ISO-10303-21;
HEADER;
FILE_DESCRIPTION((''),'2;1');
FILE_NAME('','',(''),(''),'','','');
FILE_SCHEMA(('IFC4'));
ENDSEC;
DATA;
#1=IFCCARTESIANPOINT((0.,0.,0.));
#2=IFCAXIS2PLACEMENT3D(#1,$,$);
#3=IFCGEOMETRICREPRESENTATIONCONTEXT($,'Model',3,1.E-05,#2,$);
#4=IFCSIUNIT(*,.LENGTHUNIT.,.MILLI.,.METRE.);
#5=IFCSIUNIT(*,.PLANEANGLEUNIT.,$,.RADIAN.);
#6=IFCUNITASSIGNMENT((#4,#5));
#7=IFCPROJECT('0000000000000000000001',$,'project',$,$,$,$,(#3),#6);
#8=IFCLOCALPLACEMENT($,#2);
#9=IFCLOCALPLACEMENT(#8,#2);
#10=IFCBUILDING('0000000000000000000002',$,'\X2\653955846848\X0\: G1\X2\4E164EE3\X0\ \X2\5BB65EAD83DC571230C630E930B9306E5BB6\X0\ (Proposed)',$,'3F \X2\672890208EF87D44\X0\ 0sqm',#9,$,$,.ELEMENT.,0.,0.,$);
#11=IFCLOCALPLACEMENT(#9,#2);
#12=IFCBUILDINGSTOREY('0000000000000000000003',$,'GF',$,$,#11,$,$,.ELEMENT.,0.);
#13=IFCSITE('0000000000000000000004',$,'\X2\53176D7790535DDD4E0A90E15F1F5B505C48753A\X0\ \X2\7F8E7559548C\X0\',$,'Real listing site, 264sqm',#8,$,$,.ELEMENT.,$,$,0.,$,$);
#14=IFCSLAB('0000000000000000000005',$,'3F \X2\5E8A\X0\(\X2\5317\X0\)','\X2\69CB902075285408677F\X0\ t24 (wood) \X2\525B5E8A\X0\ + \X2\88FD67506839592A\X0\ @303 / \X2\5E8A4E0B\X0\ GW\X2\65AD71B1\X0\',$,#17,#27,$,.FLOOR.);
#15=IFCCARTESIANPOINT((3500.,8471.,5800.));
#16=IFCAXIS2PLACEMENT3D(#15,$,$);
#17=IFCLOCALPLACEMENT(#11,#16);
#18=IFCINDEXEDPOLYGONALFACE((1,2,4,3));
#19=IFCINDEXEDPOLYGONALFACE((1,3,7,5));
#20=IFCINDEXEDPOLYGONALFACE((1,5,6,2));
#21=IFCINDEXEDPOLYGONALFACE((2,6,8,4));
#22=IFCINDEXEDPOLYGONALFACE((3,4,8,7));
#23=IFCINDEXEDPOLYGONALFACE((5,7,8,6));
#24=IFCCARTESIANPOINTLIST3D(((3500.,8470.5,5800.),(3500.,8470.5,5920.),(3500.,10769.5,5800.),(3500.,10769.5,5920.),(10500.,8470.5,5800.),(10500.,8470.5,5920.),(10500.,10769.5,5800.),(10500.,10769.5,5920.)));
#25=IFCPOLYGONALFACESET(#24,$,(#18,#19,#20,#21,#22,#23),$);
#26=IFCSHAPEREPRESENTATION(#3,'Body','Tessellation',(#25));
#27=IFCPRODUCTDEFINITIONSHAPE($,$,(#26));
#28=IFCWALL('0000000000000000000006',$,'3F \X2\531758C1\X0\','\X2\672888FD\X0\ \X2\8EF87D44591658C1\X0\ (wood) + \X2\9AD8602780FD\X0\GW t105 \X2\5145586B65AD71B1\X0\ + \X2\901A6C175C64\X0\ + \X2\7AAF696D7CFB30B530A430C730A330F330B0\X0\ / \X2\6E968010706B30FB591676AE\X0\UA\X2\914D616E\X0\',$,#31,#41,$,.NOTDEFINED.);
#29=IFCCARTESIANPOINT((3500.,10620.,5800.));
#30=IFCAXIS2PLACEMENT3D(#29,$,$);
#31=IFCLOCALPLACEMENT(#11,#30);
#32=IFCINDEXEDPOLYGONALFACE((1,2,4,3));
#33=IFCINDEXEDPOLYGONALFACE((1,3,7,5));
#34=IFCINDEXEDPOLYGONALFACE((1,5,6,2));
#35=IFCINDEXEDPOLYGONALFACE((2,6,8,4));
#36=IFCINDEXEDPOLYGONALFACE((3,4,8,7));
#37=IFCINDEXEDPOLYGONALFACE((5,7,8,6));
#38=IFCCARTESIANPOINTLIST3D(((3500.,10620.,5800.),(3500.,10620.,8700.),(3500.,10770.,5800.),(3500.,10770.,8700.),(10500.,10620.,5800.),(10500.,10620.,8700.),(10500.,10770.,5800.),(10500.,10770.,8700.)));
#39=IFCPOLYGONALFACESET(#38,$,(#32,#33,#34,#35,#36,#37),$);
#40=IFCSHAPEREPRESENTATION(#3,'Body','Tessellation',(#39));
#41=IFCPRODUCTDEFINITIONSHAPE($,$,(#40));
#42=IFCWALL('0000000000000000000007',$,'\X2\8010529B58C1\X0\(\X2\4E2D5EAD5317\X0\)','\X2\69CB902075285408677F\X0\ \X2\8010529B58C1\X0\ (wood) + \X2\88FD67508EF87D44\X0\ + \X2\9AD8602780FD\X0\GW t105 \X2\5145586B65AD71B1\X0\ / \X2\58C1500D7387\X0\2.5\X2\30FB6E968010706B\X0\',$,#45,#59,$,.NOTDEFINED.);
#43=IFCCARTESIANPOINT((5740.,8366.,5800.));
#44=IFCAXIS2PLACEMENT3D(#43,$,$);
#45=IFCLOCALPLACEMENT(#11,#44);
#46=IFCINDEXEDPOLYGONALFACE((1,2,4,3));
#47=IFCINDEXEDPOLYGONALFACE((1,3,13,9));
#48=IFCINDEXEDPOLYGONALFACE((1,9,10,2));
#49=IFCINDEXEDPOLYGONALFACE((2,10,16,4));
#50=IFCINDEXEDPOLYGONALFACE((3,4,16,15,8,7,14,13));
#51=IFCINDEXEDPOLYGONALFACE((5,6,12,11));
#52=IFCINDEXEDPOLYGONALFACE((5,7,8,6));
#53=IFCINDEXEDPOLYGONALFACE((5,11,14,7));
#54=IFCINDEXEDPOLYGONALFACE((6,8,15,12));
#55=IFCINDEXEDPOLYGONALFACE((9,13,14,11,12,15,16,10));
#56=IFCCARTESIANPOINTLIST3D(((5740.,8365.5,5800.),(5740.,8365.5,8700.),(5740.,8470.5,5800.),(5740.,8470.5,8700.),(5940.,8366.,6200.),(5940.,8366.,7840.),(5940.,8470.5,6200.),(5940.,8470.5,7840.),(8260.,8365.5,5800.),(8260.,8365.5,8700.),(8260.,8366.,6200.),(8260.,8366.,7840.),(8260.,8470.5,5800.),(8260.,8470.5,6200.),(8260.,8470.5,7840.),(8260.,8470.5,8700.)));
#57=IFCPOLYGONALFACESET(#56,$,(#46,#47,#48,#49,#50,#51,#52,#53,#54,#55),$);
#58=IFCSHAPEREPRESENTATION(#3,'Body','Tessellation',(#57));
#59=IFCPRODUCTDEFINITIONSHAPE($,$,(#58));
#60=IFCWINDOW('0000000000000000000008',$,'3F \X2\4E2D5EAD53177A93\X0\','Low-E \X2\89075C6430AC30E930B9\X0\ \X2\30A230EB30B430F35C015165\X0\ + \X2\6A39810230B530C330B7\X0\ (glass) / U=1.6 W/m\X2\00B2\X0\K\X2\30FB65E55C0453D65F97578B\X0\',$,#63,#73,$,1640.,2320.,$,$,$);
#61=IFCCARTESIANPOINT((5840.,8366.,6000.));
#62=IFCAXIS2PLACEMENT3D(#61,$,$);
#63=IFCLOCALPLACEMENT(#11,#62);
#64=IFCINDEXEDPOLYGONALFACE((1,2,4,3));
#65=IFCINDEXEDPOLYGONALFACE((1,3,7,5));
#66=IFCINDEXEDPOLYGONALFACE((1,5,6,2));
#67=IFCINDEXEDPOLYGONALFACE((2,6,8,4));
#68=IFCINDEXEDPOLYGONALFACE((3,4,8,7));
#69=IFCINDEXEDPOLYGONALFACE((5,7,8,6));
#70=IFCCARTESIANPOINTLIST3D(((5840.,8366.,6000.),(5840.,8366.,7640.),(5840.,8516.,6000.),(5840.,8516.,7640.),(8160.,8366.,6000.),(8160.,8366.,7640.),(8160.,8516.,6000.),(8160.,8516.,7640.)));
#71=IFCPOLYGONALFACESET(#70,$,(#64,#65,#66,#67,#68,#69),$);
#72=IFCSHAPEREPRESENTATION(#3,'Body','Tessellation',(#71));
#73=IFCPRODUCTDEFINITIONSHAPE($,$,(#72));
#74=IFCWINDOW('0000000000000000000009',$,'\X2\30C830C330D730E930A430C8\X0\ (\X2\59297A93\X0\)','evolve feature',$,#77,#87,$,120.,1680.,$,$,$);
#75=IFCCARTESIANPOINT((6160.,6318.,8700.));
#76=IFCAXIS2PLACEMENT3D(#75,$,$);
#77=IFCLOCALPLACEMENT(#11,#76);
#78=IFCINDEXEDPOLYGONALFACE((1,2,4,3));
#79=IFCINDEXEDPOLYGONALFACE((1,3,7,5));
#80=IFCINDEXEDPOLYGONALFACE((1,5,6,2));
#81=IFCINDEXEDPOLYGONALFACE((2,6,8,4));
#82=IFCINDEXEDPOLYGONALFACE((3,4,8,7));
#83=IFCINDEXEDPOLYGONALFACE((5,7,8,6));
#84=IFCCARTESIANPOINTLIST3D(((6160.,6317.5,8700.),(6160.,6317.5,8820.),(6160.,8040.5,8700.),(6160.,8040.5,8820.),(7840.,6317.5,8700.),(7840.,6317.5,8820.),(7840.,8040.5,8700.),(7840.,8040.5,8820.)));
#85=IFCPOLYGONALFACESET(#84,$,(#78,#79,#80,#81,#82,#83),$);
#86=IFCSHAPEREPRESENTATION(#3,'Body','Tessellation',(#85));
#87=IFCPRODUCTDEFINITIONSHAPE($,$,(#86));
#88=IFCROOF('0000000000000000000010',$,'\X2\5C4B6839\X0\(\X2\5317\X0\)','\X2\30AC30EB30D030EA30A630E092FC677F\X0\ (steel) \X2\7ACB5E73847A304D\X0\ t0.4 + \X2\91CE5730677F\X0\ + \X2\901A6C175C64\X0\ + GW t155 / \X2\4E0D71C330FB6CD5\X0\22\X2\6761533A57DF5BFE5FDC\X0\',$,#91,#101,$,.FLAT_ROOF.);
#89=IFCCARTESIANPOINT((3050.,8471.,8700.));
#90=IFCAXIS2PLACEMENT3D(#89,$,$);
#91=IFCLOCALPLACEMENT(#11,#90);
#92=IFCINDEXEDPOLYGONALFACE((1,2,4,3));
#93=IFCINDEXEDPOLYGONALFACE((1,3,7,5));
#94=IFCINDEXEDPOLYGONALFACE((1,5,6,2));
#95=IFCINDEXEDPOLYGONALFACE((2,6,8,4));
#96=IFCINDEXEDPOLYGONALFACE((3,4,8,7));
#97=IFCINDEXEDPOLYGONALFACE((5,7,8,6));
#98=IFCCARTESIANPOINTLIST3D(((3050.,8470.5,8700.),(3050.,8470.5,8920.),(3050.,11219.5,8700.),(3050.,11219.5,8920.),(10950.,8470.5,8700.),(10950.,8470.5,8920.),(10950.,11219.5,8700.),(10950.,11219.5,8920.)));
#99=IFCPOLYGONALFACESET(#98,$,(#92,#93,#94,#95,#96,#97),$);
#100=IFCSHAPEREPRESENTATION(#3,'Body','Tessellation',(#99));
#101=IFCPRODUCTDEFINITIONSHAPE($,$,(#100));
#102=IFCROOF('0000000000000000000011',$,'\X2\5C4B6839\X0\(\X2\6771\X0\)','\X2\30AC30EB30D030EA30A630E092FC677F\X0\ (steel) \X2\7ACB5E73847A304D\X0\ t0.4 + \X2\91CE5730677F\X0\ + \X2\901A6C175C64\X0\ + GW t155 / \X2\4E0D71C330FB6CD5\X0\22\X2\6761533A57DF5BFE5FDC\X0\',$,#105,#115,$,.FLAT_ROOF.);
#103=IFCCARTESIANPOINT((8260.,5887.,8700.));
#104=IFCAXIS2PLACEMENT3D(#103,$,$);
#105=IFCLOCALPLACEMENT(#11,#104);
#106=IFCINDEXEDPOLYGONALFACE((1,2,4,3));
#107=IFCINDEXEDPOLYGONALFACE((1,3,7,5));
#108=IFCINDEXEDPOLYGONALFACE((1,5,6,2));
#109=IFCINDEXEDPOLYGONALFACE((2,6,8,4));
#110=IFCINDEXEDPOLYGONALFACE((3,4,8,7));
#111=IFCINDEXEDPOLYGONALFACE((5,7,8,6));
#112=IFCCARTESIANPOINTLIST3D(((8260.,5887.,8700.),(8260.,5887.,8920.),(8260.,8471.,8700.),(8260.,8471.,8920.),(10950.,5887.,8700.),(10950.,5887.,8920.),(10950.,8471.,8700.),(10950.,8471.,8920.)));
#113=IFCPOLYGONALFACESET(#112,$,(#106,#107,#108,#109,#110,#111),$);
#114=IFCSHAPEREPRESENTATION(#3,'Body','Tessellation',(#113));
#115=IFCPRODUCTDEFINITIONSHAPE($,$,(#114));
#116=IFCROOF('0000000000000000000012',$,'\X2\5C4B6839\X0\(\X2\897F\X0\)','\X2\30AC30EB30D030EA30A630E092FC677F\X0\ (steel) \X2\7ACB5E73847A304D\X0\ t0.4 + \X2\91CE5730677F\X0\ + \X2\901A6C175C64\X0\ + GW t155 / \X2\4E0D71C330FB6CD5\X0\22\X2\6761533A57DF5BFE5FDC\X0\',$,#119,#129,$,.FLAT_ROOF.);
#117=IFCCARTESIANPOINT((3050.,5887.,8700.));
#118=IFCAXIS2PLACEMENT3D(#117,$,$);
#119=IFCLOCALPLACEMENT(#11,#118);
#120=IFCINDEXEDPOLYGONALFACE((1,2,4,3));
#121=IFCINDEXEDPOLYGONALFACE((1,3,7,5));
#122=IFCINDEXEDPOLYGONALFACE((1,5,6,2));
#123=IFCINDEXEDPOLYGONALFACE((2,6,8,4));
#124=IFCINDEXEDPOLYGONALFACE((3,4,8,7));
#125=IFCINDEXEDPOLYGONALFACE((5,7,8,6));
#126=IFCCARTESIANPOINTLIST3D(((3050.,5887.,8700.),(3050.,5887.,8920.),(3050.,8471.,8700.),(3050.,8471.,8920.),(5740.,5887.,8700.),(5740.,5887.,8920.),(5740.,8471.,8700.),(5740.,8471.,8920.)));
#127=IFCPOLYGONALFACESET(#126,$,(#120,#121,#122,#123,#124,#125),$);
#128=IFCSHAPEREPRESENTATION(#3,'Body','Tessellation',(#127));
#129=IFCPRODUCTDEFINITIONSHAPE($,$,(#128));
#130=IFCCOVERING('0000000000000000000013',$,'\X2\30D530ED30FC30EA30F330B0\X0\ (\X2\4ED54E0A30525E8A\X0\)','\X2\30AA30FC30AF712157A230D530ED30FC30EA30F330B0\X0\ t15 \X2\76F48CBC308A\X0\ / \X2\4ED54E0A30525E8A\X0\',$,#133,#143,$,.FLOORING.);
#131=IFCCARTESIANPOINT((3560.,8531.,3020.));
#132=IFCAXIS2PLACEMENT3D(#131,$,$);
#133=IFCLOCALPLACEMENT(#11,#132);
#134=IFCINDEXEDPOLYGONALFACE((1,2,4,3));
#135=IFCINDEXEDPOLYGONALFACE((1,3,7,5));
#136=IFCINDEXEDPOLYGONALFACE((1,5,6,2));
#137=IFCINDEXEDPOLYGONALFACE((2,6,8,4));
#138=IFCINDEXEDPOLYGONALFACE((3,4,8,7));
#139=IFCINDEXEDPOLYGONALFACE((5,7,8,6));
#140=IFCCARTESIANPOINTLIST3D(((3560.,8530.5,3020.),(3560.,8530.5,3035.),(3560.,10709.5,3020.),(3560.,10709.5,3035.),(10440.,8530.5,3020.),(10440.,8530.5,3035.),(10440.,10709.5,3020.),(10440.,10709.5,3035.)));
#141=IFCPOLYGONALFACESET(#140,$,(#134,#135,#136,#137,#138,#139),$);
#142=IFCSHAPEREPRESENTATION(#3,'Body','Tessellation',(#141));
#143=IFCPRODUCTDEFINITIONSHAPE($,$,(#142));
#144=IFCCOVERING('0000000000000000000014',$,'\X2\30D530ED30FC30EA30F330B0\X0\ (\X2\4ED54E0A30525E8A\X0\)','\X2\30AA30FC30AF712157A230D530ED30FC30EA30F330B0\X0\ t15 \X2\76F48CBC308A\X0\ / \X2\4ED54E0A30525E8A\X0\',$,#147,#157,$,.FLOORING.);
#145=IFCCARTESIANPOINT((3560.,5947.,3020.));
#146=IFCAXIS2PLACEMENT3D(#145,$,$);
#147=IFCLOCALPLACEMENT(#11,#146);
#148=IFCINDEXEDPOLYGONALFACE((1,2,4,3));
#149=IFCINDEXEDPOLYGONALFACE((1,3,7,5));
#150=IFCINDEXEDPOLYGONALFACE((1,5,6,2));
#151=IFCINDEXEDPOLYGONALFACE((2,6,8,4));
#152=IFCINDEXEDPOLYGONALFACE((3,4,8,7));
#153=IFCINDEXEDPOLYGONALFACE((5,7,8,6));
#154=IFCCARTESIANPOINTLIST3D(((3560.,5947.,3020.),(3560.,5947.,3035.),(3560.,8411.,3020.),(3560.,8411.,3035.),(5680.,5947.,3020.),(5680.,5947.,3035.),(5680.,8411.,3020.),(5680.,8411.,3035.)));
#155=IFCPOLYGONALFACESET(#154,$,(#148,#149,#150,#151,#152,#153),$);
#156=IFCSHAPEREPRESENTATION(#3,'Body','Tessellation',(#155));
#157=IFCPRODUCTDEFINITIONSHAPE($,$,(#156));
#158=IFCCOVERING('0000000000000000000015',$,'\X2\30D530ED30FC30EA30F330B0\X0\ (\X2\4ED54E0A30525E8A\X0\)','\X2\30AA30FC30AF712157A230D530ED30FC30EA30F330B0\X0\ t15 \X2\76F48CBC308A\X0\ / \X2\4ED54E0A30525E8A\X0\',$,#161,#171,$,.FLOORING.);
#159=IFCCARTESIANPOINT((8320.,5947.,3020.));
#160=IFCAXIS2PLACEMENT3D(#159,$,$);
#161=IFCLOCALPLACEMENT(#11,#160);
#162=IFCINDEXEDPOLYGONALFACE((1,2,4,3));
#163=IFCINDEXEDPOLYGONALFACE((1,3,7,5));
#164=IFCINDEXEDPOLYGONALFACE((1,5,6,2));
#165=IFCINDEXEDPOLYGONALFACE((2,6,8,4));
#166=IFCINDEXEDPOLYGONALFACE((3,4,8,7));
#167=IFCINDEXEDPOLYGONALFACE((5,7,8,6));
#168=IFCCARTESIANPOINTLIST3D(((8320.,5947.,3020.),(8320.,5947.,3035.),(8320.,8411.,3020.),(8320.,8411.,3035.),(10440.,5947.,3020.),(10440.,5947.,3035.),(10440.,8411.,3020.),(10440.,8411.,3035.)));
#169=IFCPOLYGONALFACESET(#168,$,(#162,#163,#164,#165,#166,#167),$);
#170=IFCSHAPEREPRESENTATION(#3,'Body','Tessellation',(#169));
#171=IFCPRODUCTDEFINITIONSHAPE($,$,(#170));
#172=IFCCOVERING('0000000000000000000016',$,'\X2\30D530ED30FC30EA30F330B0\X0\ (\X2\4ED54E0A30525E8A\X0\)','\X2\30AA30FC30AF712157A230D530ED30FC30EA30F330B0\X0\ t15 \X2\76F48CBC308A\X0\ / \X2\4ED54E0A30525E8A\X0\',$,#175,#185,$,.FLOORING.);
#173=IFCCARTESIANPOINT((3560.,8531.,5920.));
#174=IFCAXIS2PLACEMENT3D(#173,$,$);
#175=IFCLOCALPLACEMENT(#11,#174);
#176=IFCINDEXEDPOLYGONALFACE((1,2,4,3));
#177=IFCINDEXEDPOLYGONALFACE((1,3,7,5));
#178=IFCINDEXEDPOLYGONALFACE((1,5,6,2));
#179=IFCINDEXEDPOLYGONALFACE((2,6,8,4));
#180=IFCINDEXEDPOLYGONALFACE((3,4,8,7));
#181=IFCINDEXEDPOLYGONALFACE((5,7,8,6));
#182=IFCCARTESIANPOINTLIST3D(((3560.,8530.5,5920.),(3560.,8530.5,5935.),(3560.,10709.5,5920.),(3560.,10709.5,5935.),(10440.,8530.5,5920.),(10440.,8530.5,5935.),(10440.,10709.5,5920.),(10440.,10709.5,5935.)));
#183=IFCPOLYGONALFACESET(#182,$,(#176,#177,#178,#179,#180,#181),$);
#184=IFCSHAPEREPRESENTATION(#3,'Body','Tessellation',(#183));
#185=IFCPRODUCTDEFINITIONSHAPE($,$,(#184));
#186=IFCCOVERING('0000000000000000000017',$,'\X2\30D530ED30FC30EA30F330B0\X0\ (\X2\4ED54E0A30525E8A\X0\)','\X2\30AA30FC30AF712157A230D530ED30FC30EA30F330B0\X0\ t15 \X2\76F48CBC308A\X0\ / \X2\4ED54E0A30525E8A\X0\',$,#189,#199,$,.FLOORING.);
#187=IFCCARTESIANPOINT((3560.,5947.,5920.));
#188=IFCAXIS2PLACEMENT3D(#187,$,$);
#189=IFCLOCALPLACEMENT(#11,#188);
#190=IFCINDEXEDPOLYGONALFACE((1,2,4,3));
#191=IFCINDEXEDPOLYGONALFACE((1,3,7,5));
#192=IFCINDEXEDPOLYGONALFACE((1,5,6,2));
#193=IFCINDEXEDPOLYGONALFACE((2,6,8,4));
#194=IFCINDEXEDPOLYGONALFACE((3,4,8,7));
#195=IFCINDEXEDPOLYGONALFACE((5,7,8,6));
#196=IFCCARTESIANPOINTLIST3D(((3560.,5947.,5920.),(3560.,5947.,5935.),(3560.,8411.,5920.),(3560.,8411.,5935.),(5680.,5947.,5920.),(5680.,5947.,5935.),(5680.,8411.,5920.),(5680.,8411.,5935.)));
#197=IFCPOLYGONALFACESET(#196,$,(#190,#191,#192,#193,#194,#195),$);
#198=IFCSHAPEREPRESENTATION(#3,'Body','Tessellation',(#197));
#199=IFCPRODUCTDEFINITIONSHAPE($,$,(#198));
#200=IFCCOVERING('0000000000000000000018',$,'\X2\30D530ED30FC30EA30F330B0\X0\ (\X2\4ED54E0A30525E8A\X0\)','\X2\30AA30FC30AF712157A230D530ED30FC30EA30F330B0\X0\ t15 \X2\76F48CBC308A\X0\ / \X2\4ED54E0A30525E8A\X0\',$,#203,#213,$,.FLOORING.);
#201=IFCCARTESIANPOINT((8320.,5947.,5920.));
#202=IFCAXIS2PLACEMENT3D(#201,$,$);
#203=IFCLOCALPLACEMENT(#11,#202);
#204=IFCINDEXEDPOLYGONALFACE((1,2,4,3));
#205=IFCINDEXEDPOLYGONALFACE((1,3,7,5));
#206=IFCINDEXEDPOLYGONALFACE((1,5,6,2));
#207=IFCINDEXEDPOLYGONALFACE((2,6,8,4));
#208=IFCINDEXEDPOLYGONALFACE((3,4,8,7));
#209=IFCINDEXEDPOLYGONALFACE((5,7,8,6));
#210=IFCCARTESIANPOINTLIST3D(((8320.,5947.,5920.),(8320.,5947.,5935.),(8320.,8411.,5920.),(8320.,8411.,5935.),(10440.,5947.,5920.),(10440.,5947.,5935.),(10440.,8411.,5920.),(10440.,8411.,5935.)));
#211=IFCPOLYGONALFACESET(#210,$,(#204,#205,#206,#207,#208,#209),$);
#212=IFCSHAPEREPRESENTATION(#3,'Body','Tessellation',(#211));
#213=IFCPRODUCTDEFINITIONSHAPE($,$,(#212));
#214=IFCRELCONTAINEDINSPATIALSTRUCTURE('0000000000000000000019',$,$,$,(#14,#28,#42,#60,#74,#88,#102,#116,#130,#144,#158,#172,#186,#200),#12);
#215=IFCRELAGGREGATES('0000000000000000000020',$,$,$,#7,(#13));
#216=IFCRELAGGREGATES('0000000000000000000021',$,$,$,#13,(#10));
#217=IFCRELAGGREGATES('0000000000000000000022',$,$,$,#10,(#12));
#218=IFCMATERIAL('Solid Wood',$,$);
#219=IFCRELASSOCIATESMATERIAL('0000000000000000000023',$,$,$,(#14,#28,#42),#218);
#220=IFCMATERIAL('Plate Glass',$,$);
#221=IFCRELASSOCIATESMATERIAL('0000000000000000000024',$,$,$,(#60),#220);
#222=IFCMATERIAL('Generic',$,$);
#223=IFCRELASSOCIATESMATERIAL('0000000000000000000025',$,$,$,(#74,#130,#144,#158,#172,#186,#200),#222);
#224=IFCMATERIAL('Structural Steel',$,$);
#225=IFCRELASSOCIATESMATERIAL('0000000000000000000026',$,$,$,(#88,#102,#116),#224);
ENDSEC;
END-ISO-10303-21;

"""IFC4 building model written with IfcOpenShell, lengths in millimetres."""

from ifc_helpers import new_model, si_unit, frame, frame_2d, origin, place, context, project, spatial, rectangle, extrude, material, element, fill, save


model = new_model("IFC4")

# Units and contexts
model_context = context("Model", 3, precision=1e-05, world=origin())
ifc_project = project(units=[si_unit("LENGTHUNIT", "METRE", prefix="MILLI"), si_unit("PLANEANGLEUNIT", "RADIAN")], contexts=[model_context])

# Site, building, storey
site_placement = place(None, origin())
site = spatial("IfcSite", under=ifc_project, at=site_placement, Name="北海道川上郡弟子屈町 美留和", ObjectType="Real listing site, 264sqm", CompositionType="ELEMENT", RefElevation=0.0)
building_placement = place(site_placement, origin())
building = spatial("IfcBuilding", under=site, at=building_placement, Name="改善案: G1世代 家庭菜園テラスの家 (Proposed)", ObjectType="3F 木造軸組 0sqm", CompositionType="ELEMENT", ElevationOfRefHeight=0.0, ElevationOfTerrain=0.0)
storey_placement = place(building_placement, origin())
storey = spatial("IfcBuildingStorey", under=building, at=storey_placement, Name="GF", CompositionType="ELEMENT", Elevation=0.0)

# Slab
ifc_material_1 = material(Name="Solid Wood")
slab_placement = place(storey_placement, frame((3500.0, 8471.0, 5800.0)))
element("IfcSlab", 1, at=slab_placement, inside=storey, material=ifc_material_1, Name="3F 床(北)", Description="構造用合板 t24 (wood) 剛床 + 製材根太 @303 / 床下 GW断熱", PredefinedType="FLOOR", context=model_context, shape_type="SweptSolid", body=[
    extrude(rectangle(XDim=7000.0, YDim=2299.0, at=frame_2d((3500.0, 1149.0))), frame((3500.0, 8471.0, 5800.0)), (0.0, 0.0, 1.0), 120.0),
])

# Wall
wall_1_placement = place(storey_placement, frame((3500.0, 10620.0, 5800.0)))
element("IfcWall", 2, at=wall_1_placement, inside=storey, material=ifc_material_1, Name="3F 北壁", Description="木製 軸組外壁 (wood) + 高性能GW t105 充填断熱 + 通気層 + 窯業系サイディング / 準耐火・外皮UA配慮", PredefinedType="NOTDEFINED", context=model_context, shape_type="SweptSolid", body=[
    extrude(rectangle(XDim=7000.0, YDim=150.0, at=frame_2d((3500.0, 75.0))), frame((3500.0, 10620.0, 5800.0)), (0.0, 0.0, 1.0), 2900.0),
])

# Wall, opening, window
wall_2_placement = place(storey_placement, frame((5740.0, 8366.0, 5800.0)))
wall_2 = element("IfcWall", 3, at=wall_2_placement, inside=storey, material=ifc_material_1, Name="耐力壁(中庭北)", Description="構造用合板 耐力壁 (wood) + 製材軸組 + 高性能GW t105 充填断熱 / 壁倍率2.5・準耐火", PredefinedType="NOTDEFINED", context=model_context, shape_type="SweptSolid", body=[
    extrude(rectangle(XDim=2520.0, YDim=105.0, at=frame_2d((1260.0, 52.0))), frame((5740.0, 8366.0, 5800.0)), (0.0, 0.0, 1.0), 2900.0),
])
opening_placement = place(storey_placement, frame((5840.0, 8366.0, 6000.0)))
opening = element("IfcOpeningElement", 4, at=opening_placement, cuts=wall_2, PredefinedType="NOTDEFINED", context=model_context, shape_type="SweptSolid", body=[
    extrude(rectangle(XDim=2320.0, YDim=150.0, at=frame_2d((1160.0, 75.0))), frame((5840.0, 8366.0, 6000.0)), (0.0, 0.0, 1.0), 1640.0),
])
ifc_material_2 = material(Name="Plate Glass")
window_1_placement = place(storey_placement, frame((5840.0, 8366.0, 6000.0)))
window_1 = element("IfcWindow", 5, at=window_1_placement, inside=storey, material=ifc_material_2, Name="3F 中庭北窓", Description="Low-E 複層ガラス アルゴン封入 + 樹脂サッシ (glass) / U=1.6 W/m²K・日射取得型", OverallHeight=1640.0, OverallWidth=2320.0, context=model_context, shape_type="SweptSolid", body=[
    extrude(rectangle(XDim=2320.0, YDim=150.0, at=frame_2d((1160.0, 75.0))), frame((5840.0, 8366.0, 6000.0)), (0.0, 0.0, 1.0), 1640.0),
])
fill(opening, window_1)

# Window
ifc_material_3 = material(Name="Generic")
window_2_placement = place(storey_placement, frame((6160.0, 6318.0, 8700.0)))
element("IfcWindow", 6, at=window_2_placement, inside=storey, material=ifc_material_3, Name="トップライト (天窓)", Description="evolve feature", OverallHeight=120.0, OverallWidth=1680.0, context=model_context, shape_type="SweptSolid", body=[
    extrude(rectangle(XDim=1680.0, YDim=1723.0, at=frame_2d((840.0, 861.0))), frame((6160.0, 6318.0, 8700.0)), (0.0, 0.0, 1.0), 120.0),
])

# Roofs
ifc_material_4 = material(Name="Structural Steel")
roof_1_placement = place(storey_placement, frame((3050.0, 8471.0, 8700.0)))
element("IfcRoof", 7, at=roof_1_placement, inside=storey, material=ifc_material_4, Name="屋根(北)", Description="ガルバリウム鋼板 (steel) 立平葺き t0.4 + 野地板 + 通気層 + GW t155 / 不燃・法22条区域対応", PredefinedType="FLAT_ROOF", context=model_context, shape_type="SweptSolid", body=[
    extrude(rectangle(XDim=7900.0, YDim=2749.0, at=frame_2d((3950.0, 1374.0))), frame((3050.0, 8471.0, 8700.0)), (0.0, 0.0, 1.0), 220.0),
])
roof_2_placement = place(storey_placement, frame((8260.0, 5887.0, 8700.0)))
element("IfcRoof", 8, at=roof_2_placement, inside=storey, material=ifc_material_4, Name="屋根(東)", Description="ガルバリウム鋼板 (steel) 立平葺き t0.4 + 野地板 + 通気層 + GW t155 / 不燃・法22条区域対応", PredefinedType="FLAT_ROOF", context=model_context, shape_type="SweptSolid", body=[
    extrude(rectangle(XDim=2690.0, YDim=2584.0, at=frame_2d((1345.0, 1292.0))), frame((8260.0, 5887.0, 8700.0)), (0.0, 0.0, 1.0), 220.0),
])
roof_3_placement = place(storey_placement, frame((3050.0, 5887.0, 8700.0)))
element("IfcRoof", 9, at=roof_3_placement, inside=storey, material=ifc_material_4, Name="屋根(西)", Description="ガルバリウム鋼板 (steel) 立平葺き t0.4 + 野地板 + 通気層 + GW t155 / 不燃・法22条区域対応", PredefinedType="FLAT_ROOF", context=model_context, shape_type="SweptSolid", body=[
    extrude(rectangle(XDim=2690.0, YDim=2584.0, at=frame_2d((1345.0, 1292.0))), frame((3050.0, 5887.0, 8700.0)), (0.0, 0.0, 1.0), 220.0),
])

# Coverings
covering_1_placement = place(storey_placement, frame((3560.0, 8531.0, 3020.0)))
element("IfcCovering", 10, at=covering_1_placement, inside=storey, material=ifc_material_3, Name="フローリング (仕上げ床)", Description="オーク無垢フローリング t15 直貼り / 仕上げ床", PredefinedType="FLOORING", context=model_context, shape_type="SweptSolid", body=[
    extrude(rectangle(XDim=6880.0, YDim=2179.0, at=frame_2d((3440.0, 1089.0))), frame((3560.0, 8531.0, 3020.0)), (0.0, 0.0, 1.0), 15.0),
])
covering_2_placement = place(storey_placement, frame((3560.0, 5947.0, 3020.0)))
element("IfcCovering", 11, at=covering_2_placement, inside=storey, material=ifc_material_3, Name="フローリング (仕上げ床)", Description="オーク無垢フローリング t15 直貼り / 仕上げ床", PredefinedType="FLOORING", context=model_context, shape_type="SweptSolid", body=[
    extrude(rectangle(XDim=2120.0, YDim=2464.0, at=frame_2d((1060.0, 1232.0))), frame((3560.0, 5947.0, 3020.0)), (0.0, 0.0, 1.0), 15.0),
])
covering_3_placement = place(storey_placement, frame((8320.0, 5947.0, 3020.0)))
element("IfcCovering", 12, at=covering_3_placement, inside=storey, material=ifc_material_3, Name="フローリング (仕上げ床)", Description="オーク無垢フローリング t15 直貼り / 仕上げ床", PredefinedType="FLOORING", context=model_context, shape_type="SweptSolid", body=[
    extrude(rectangle(XDim=2120.0, YDim=2464.0, at=frame_2d((1060.0, 1232.0))), frame((8320.0, 5947.0, 3020.0)), (0.0, 0.0, 1.0), 15.0),
])
covering_4_placement = place(storey_placement, frame((3560.0, 8531.0, 5920.0)))
element("IfcCovering", 13, at=covering_4_placement, inside=storey, material=ifc_material_3, Name="フローリング (仕上げ床)", Description="オーク無垢フローリング t15 直貼り / 仕上げ床", PredefinedType="FLOORING", context=model_context, shape_type="SweptSolid", body=[
    extrude(rectangle(XDim=6880.0, YDim=2179.0, at=frame_2d((3440.0, 1089.0))), frame((3560.0, 8531.0, 5920.0)), (0.0, 0.0, 1.0), 15.0),
])
covering_5_placement = place(storey_placement, frame((3560.0, 5947.0, 5920.0)))
element("IfcCovering", 14, at=covering_5_placement, inside=storey, material=ifc_material_3, Name="フローリング (仕上げ床)", Description="オーク無垢フローリング t15 直貼り / 仕上げ床", PredefinedType="FLOORING", context=model_context, shape_type="SweptSolid", body=[
    extrude(rectangle(XDim=2120.0, YDim=2464.0, at=frame_2d((1060.0, 1232.0))), frame((3560.0, 5947.0, 5920.0)), (0.0, 0.0, 1.0), 15.0),
])
covering_6_placement = place(storey_placement, frame((8320.0, 5947.0, 5920.0)))
element("IfcCovering", 15, at=covering_6_placement, inside=storey, material=ifc_material_3, Name="フローリング (仕上げ床)", Description="オーク無垢フローリング t15 直貼り / 仕上げ床", PredefinedType="FLOORING", context=model_context, shape_type="SweptSolid", body=[
    extrude(rectangle(XDim=2120.0, YDim=2464.0, at=frame_2d((1060.0, 1232.0))), frame((8320.0, 5947.0, 5920.0)), (0.0, 0.0, 1.0), 15.0),
])

save(model, "model.ifc")
